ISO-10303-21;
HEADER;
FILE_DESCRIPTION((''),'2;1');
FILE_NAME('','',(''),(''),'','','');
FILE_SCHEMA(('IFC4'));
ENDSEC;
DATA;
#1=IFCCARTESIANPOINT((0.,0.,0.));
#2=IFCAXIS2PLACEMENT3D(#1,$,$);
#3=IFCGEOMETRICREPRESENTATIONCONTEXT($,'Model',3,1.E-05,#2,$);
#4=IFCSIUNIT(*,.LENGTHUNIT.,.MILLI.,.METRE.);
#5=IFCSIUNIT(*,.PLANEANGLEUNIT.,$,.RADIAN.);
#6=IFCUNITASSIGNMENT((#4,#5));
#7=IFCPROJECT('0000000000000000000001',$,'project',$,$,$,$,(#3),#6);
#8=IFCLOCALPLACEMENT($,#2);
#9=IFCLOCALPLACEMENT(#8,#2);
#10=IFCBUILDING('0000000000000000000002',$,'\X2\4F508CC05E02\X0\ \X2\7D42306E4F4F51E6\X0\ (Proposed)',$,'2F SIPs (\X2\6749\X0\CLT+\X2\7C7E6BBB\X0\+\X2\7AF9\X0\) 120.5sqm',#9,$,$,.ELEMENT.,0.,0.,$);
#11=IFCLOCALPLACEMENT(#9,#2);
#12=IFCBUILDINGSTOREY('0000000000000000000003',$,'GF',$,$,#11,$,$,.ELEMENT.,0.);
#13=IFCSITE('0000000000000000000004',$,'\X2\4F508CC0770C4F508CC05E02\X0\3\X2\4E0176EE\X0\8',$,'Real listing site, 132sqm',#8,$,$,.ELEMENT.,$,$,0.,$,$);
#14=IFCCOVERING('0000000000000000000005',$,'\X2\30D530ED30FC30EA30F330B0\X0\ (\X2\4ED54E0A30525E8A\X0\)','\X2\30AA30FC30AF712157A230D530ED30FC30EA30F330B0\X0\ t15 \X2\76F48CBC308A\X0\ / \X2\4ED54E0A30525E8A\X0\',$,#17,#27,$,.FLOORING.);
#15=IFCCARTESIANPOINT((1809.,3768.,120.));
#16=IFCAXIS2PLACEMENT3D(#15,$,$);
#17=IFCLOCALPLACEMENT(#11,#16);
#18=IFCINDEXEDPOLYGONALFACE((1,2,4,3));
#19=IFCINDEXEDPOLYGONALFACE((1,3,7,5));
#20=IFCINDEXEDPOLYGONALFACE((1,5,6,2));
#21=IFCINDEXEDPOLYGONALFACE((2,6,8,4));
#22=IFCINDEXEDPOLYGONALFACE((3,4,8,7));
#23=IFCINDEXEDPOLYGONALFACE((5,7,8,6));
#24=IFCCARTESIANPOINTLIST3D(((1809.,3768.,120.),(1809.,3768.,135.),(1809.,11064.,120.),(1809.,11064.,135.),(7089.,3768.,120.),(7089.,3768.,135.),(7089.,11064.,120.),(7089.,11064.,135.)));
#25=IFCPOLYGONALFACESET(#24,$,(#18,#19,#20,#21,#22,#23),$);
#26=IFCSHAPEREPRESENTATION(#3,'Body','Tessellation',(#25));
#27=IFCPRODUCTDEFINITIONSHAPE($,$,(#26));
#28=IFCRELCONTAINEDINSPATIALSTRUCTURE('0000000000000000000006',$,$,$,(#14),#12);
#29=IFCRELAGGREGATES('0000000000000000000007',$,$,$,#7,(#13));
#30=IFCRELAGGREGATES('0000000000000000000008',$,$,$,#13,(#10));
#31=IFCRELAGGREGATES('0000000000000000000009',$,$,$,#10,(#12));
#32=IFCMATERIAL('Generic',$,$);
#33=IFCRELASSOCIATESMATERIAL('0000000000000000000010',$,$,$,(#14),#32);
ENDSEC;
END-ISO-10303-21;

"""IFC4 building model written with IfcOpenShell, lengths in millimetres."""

from ifc_helpers import new_model, si_unit, frame, frame_2d, origin, place, context, project, spatial, rectangle, extrude, material, element, save


model = new_model("IFC4")

# Units and contexts
model_context = context("Model", 3, precision=1e-05, world=origin())
ifc_project = project(units=[si_unit("LENGTHUNIT", "METRE", prefix="MILLI"), si_unit("PLANEANGLEUNIT", "RADIAN")], contexts=[model_context])

# Site, building, storey
site_placement = place(None, origin())
site = spatial("IfcSite", under=ifc_project, at=site_placement, Name="佐賀県佐賀市3丁目8", ObjectType="Real listing site, 132sqm", CompositionType="ELEMENT", RefElevation=0.0)
building_placement = place(site_placement, origin())
building = spatial("IfcBuilding", under=site, at=building_placement, Name="佐賀市 終の住処 (Proposed)", ObjectType="2F SIPs (杉CLT+籾殻+竹) 120.5sqm", CompositionType="ELEMENT", ElevationOfRefHeight=0.0, ElevationOfTerrain=0.0)
storey_placement = place(building_placement, origin())
storey = spatial("IfcBuildingStorey", under=building, at=storey_placement, Name="GF", CompositionType="ELEMENT", Elevation=0.0)

# Shared definitions
ifc_material_1 = material(Name="Generic")

# Covering
covering_placement = place(storey_placement, frame((1809.0, 3768.0, 120.0)))
element("IfcCovering", 1, at=covering_placement, inside=storey, material=ifc_material_1, Name="フローリング (仕上げ床)", Description="オーク無垢フローリング t15 直貼り / 仕上げ床", PredefinedType="FLOORING", context=model_context, shape_type="SweptSolid", body=[
    extrude(rectangle(XDim=5280.0, YDim=7296.0, at=frame_2d((2640.0, 3648.0))), frame((1809.0, 3768.0, 120.0)), (0.0, 0.0, 1.0), 15.0),
])

save(model, "model.ifc")
